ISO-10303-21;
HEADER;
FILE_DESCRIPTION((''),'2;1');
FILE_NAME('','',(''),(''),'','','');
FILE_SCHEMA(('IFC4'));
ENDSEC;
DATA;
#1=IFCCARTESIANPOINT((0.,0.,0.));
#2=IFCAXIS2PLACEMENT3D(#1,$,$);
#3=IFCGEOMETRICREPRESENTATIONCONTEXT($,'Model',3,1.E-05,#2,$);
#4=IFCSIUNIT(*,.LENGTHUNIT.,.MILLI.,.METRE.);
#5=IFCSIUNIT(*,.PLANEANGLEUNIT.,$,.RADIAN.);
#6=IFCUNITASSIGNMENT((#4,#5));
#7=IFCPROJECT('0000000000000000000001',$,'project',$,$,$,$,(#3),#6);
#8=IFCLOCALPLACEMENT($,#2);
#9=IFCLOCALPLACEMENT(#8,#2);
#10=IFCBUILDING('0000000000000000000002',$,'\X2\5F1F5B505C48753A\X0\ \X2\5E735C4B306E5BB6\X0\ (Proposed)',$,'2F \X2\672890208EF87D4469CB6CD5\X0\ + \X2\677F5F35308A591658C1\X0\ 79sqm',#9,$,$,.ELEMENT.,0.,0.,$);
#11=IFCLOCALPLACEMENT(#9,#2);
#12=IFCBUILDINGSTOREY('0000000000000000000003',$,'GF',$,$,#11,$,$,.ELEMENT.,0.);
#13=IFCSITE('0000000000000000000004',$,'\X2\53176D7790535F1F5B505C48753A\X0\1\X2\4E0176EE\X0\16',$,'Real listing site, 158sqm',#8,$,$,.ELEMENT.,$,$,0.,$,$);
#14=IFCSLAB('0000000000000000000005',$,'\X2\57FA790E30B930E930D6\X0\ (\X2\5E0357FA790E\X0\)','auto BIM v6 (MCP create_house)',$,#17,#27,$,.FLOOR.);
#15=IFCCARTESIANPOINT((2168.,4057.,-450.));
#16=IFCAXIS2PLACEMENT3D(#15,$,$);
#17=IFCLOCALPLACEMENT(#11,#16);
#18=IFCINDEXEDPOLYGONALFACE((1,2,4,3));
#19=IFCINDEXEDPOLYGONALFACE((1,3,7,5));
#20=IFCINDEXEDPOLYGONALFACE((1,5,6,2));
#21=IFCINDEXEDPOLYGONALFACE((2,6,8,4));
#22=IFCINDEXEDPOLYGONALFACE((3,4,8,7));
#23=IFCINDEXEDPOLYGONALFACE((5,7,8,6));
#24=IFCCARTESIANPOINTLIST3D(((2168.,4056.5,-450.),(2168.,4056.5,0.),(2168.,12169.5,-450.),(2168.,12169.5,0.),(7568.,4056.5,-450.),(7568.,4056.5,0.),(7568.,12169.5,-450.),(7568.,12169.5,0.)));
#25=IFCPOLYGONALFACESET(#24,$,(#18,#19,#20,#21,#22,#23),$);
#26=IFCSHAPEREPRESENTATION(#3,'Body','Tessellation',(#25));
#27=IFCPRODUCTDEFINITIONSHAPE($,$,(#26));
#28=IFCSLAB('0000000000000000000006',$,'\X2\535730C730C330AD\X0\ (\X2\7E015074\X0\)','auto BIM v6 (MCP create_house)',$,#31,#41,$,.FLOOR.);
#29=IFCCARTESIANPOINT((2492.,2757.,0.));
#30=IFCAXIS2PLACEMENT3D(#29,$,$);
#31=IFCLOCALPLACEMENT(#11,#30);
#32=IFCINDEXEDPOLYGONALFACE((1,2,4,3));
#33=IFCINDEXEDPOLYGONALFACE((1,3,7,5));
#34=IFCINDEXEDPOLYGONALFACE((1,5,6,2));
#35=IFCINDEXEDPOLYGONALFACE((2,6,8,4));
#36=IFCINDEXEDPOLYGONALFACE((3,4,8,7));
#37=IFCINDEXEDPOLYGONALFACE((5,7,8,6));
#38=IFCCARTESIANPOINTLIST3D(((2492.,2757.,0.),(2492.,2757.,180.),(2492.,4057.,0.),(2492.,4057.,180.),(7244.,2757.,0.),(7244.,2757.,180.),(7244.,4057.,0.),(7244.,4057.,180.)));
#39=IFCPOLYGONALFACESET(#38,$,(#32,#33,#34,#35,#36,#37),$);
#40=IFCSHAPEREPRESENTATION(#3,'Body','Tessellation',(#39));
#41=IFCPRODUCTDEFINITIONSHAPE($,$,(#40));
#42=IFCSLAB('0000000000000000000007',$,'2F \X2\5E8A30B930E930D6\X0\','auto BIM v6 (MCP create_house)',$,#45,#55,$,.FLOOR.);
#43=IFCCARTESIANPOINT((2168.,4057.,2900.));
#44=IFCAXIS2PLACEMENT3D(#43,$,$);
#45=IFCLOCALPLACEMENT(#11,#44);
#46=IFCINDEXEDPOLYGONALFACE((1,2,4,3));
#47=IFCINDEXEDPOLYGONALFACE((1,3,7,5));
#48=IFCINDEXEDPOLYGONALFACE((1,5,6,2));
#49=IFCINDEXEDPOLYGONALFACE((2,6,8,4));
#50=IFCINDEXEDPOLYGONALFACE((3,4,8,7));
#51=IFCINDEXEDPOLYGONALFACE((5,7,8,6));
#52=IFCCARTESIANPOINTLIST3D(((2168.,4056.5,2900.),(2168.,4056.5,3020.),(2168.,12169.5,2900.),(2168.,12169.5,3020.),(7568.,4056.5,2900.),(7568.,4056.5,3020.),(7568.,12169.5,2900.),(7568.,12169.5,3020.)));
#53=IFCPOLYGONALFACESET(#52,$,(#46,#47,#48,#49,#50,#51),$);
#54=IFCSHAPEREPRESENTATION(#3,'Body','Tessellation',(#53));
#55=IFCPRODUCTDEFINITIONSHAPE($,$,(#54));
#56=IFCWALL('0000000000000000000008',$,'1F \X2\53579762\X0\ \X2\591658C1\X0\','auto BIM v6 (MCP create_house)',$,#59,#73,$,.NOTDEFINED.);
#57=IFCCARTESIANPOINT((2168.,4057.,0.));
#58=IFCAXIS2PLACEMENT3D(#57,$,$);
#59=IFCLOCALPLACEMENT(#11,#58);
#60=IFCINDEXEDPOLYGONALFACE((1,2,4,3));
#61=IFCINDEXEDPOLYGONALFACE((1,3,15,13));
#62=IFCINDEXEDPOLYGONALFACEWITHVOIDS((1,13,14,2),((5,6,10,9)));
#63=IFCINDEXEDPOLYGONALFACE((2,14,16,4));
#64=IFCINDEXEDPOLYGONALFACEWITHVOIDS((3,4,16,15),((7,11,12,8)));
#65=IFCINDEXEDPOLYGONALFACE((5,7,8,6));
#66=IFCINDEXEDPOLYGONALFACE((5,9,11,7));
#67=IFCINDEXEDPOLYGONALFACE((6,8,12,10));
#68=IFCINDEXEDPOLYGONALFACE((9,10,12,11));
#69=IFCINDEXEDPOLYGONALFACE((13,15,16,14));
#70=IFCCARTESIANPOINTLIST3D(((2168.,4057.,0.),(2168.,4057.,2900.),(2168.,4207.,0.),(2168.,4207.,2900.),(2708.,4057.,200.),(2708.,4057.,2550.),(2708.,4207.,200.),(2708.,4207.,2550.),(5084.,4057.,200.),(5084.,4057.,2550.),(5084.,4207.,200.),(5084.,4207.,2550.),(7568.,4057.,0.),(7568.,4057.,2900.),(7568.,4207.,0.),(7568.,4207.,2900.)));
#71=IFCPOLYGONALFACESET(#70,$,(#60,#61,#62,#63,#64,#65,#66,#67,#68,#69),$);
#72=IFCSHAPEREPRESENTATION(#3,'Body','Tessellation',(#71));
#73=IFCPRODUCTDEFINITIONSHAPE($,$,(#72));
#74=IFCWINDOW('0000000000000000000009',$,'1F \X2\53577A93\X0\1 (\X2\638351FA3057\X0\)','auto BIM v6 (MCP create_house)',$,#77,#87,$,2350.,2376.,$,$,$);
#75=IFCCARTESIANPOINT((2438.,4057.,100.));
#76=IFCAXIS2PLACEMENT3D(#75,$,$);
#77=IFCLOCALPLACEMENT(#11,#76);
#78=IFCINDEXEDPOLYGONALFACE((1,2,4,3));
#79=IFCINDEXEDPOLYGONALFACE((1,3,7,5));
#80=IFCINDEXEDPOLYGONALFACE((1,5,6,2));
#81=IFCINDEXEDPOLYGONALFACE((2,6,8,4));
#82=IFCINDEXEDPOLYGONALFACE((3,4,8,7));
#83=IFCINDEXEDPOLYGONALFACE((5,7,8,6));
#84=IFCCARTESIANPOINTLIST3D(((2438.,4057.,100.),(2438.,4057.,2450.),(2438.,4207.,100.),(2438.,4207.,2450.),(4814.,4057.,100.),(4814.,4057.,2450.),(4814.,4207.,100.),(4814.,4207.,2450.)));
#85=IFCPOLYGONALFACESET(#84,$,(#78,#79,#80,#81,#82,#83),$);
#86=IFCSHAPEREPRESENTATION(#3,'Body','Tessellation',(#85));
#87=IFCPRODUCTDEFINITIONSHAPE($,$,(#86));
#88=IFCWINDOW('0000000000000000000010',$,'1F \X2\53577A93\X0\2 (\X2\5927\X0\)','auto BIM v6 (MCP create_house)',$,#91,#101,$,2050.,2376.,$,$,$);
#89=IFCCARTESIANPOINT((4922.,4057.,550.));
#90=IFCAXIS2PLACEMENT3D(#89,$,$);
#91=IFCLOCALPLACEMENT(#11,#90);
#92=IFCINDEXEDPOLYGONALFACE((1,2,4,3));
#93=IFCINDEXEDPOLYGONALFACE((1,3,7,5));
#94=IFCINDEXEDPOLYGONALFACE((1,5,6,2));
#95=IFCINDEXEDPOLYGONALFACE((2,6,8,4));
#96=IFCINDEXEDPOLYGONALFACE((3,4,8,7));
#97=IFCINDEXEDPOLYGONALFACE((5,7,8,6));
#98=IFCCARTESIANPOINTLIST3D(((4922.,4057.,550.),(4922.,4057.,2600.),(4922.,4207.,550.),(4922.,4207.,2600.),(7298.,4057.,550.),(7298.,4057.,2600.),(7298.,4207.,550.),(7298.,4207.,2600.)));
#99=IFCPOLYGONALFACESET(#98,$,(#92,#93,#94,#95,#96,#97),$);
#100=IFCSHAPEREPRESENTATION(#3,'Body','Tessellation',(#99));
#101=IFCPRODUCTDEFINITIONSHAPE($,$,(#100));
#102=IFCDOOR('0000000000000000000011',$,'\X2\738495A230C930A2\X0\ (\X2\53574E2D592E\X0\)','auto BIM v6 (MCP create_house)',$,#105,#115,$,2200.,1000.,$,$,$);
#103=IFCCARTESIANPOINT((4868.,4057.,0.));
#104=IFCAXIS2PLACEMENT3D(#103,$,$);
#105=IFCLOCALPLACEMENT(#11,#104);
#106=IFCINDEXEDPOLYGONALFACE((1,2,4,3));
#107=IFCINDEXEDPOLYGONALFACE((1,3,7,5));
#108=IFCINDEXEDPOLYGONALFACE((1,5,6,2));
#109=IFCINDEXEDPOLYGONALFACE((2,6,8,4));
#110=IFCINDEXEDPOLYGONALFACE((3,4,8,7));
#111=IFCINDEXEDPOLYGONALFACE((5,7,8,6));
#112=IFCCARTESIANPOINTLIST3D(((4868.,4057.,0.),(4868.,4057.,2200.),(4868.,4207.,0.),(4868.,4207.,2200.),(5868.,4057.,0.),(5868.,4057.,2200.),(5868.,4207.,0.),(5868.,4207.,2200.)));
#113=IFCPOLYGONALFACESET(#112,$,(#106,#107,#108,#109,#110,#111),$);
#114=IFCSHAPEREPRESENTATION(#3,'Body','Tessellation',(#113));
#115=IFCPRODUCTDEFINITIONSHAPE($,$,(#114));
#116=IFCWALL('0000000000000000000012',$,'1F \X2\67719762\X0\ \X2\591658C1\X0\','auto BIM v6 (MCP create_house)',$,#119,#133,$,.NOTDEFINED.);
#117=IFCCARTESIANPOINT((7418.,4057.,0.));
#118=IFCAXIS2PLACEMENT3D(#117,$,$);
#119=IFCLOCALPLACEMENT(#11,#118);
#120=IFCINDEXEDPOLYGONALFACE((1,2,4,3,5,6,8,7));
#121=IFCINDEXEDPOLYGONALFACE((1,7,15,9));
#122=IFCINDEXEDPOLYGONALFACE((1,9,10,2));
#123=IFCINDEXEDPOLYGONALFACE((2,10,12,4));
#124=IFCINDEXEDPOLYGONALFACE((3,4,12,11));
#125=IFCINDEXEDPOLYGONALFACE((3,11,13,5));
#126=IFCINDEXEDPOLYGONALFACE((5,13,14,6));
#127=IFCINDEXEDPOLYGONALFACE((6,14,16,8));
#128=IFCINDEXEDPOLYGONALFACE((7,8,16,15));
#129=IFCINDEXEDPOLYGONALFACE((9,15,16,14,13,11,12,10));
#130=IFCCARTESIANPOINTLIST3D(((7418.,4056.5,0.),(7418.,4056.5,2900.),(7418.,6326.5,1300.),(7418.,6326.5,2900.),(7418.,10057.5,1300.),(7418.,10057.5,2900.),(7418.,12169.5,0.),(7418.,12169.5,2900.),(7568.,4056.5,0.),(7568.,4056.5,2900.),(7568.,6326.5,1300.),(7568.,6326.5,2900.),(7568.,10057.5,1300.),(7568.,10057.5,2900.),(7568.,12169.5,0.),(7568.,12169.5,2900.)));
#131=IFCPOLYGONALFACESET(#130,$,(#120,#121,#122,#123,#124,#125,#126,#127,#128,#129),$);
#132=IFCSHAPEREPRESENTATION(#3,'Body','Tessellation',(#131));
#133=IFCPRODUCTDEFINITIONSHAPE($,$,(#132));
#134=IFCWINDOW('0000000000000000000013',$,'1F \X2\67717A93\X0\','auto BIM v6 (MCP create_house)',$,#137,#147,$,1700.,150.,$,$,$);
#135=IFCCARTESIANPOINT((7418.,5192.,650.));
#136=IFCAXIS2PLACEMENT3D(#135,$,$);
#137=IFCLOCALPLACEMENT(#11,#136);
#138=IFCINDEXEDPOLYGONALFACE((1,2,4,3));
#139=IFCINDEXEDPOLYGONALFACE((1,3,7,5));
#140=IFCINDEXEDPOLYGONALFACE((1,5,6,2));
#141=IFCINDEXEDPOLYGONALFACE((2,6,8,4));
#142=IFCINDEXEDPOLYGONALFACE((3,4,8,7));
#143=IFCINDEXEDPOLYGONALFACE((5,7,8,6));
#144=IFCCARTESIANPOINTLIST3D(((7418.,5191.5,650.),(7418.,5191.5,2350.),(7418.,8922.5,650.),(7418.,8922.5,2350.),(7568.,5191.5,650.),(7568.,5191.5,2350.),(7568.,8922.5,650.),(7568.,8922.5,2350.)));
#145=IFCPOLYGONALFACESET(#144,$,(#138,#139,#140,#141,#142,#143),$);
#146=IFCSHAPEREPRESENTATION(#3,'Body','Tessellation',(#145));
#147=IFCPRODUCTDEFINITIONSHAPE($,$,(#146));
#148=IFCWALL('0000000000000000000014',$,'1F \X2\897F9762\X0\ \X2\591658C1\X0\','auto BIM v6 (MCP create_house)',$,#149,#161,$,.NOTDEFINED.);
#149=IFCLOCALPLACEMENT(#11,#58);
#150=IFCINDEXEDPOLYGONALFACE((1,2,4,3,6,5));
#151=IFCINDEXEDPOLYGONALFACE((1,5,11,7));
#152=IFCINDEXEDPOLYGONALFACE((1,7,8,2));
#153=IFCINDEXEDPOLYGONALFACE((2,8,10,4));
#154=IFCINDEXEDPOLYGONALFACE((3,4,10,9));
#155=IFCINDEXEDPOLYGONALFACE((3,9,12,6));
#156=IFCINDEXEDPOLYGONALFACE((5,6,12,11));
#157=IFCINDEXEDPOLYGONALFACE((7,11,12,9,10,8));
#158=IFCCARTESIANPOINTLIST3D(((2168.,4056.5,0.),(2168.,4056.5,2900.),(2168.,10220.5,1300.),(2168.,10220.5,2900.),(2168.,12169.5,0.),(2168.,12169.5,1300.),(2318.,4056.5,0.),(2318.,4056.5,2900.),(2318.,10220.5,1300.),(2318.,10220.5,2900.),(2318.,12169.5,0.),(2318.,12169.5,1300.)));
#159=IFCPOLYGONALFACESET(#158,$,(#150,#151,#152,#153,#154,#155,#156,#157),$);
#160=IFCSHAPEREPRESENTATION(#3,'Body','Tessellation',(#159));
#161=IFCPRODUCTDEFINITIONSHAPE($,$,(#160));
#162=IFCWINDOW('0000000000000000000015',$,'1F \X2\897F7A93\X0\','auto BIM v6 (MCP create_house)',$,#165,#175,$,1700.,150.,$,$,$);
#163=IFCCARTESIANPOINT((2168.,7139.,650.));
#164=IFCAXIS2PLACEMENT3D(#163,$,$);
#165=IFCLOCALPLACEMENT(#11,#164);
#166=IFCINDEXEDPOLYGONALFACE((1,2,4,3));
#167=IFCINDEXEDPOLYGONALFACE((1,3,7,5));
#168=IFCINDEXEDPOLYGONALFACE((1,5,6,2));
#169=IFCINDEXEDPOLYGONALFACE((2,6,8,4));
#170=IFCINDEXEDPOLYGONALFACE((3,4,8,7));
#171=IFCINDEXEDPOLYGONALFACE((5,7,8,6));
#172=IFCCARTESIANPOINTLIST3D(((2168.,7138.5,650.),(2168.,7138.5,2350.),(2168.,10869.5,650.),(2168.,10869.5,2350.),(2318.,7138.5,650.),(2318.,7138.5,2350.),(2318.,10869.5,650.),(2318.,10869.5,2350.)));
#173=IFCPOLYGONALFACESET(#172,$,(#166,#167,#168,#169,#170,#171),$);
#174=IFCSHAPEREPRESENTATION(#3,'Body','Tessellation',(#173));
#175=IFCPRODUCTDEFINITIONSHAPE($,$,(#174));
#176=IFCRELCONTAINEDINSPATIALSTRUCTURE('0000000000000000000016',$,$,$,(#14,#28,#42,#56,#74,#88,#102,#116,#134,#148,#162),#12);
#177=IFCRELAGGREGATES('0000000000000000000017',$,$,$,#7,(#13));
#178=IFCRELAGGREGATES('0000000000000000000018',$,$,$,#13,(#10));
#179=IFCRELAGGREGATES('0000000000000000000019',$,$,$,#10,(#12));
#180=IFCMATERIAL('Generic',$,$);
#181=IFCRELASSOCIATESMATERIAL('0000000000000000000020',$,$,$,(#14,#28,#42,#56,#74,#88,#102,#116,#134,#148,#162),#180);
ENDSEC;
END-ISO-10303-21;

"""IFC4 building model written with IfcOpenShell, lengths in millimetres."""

from ifc_helpers import new_model, si_unit, frame, frame_2d, origin, place, context, project, spatial, rectangle, extrude, material, element, fill, save


model = new_model("IFC4")

# Units and contexts
model_context = context("Model", 3, precision=1e-05, world=origin())
ifc_project = project(units=[si_unit("LENGTHUNIT", "METRE", prefix="MILLI"), si_unit("PLANEANGLEUNIT", "RADIAN")], contexts=[model_context])

# Site, building, storey
site_placement = place(None, origin())
site = spatial("IfcSite", under=ifc_project, at=site_placement, Name="北海道弟子屈町1丁目16", ObjectType="Real listing site, 158sqm", CompositionType="ELEMENT", RefElevation=0.0)
building_placement = place(site_placement, origin())
building = spatial("IfcBuilding", under=site, at=building_placement, Name="弟子屈町 平屋の家 (Proposed)", ObjectType="2F 木造軸組構法 + 板張り外壁 79sqm", CompositionType="ELEMENT", ElevationOfRefHeight=0.0, ElevationOfTerrain=0.0)
storey_placement = place(building_placement, origin())
storey = spatial("IfcBuildingStorey", under=building, at=storey_placement, Name="GF", CompositionType="ELEMENT", Elevation=0.0)

# Slabs
ifc_material = material(Name="Generic")
slab_1_placement = place(storey_placement, frame((2168.0, 4057.0, -450.0)))
element("IfcSlab", 1, at=slab_1_placement, inside=storey, material=ifc_material, Name="基礎スラブ (布基礎)", Description="auto BIM v6 (MCP create_house)", PredefinedType="FLOOR", context=model_context, shape_type="SweptSolid", body=[
    extrude(rectangle(XDim=5400.0, YDim=8113.0, at=frame_2d((2700.0, 4056.0))), frame((2168.0, 4057.0, -450.0)), (0.0, 0.0, 1.0), 450.0),
])
slab_2_placement = place(storey_placement, frame((2492.0, 2757.0, 0.0)))
element("IfcSlab", 2, at=slab_2_placement, inside=storey, material=ifc_material, Name="南デッキ (縁側)", Description="auto BIM v6 (MCP create_house)", PredefinedType="FLOOR", context=model_context, shape_type="SweptSolid", body=[
    extrude(rectangle(XDim=4752.0, YDim=1300.0, at=frame_2d((2376.0, 650.0))), frame((2492.0, 2757.0, 0.0)), (0.0, 0.0, 1.0), 180.0),
])
slab_3_placement = place(storey_placement, frame((2168.0, 4057.0, 2900.0)))
element("IfcSlab", 3, at=slab_3_placement, inside=storey, material=ifc_material, Name="2F 床スラブ", Description="auto BIM v6 (MCP create_house)", PredefinedType="FLOOR", context=model_context, shape_type="SweptSolid", body=[
    extrude(rectangle(XDim=5400.0, YDim=8113.0, at=frame_2d((2700.0, 4056.0))), frame((2168.0, 4057.0, 2900.0)), (0.0, 0.0, 1.0), 120.0),
])

# Wall, openings, windows, door
wall_1_placement = place(storey_placement, frame((2168.0, 4057.0, 0.0)))
wall_1 = element("IfcWall", 4, at=wall_1_placement, inside=storey, material=ifc_material, Name="1F 南面 外壁", Description="auto BIM v6 (MCP create_house)", PredefinedType="NOTDEFINED", context=model_context, shape_type="SweptSolid", body=[
    extrude(rectangle(XDim=5400.0, YDim=150.0, at=frame_2d((2700.0, 75.0))), frame((2168.0, 4057.0, 0.0)), (0.0, 0.0, 1.0), 2900.0),
])
opening_1_placement = place(storey_placement, frame((2438.0, 4057.0, 100.0)))
opening_1 = element("IfcOpeningElement", 5, at=opening_1_placement, cuts=wall_1, PredefinedType="NOTDEFINED", context=model_context, shape_type="SweptSolid", body=[
    extrude(rectangle(XDim=2376.0, YDim=150.0, at=frame_2d((1188.0, 75.0))), frame((2438.0, 4057.0, 100.0)), (0.0, 0.0, 1.0), 2350.0),
])
opening_2_placement = place(storey_placement, frame((4922.0, 4057.0, 550.0)))
opening_2 = element("IfcOpeningElement", 6, at=opening_2_placement, cuts=wall_1, PredefinedType="NOTDEFINED", context=model_context, shape_type="SweptSolid", body=[
    extrude(rectangle(XDim=2376.0, YDim=150.0, at=frame_2d((1188.0, 75.0))), frame((4922.0, 4057.0, 550.0)), (0.0, 0.0, 1.0), 2050.0),
])
opening_3_placement = place(storey_placement, frame((4868.0, 4057.0, 0.0)))
opening_3 = element("IfcOpeningElement", 7, at=opening_3_placement, cuts=wall_1, PredefinedType="NOTDEFINED", context=model_context, shape_type="SweptSolid", body=[
    extrude(rectangle(XDim=1000.0, YDim=150.0, at=frame_2d((500.0, 75.0))), frame((4868.0, 4057.0, 0.0)), (0.0, 0.0, 1.0), 2200.0),
])
window_1_placement = place(storey_placement, frame((2438.0, 4057.0, 100.0)))
window_1 = element("IfcWindow", 8, at=window_1_placement, inside=storey, material=ifc_material, Name="1F 南窓1 (掃出し)", Description="auto BIM v6 (MCP create_house)", OverallHeight=2350.0, OverallWidth=2376.0, context=model_context, shape_type="SweptSolid", body=[
    extrude(rectangle(XDim=2376.0, YDim=150.0, at=frame_2d((1188.0, 75.0))), frame((2438.0, 4057.0, 100.0)), (0.0, 0.0, 1.0), 2350.0),
])
fill(opening_1, window_1)
window_2_placement = place(storey_placement, frame((4922.0, 4057.0, 550.0)))
window_2 = element("IfcWindow", 9, at=window_2_placement, inside=storey, material=ifc_material, Name="1F 南窓2 (大)", Description="auto BIM v6 (MCP create_house)", OverallHeight=2050.0, OverallWidth=2376.0, context=model_context, shape_type="SweptSolid", body=[
    extrude(rectangle(XDim=2376.0, YDim=150.0, at=frame_2d((1188.0, 75.0))), frame((4922.0, 4057.0, 550.0)), (0.0, 0.0, 1.0), 2050.0),
])
fill(opening_2, window_2)
door_placement = place(storey_placement, frame((4868.0, 4057.0, 0.0)))
door = element("IfcDoor", 10, at=door_placement, inside=storey, material=ifc_material, Name="玄関ドア (南中央)", Description="auto BIM v6 (MCP create_house)", OverallHeight=2200.0, OverallWidth=1000.0, context=model_context, shape_type="SweptSolid", body=[
    extrude(rectangle(XDim=1000.0, YDim=150.0, at=frame_2d((500.0, 75.0))), frame((4868.0, 4057.0, 0.0)), (0.0, 0.0, 1.0), 2200.0),
])
fill(opening_3, door)

# Walls, openings, windows
wall_2_placement = place(storey_placement, frame((7418.0, 4057.0, 0.0)))
wall_2 = element("IfcWall", 11, at=wall_2_placement, inside=storey, material=ifc_material, Name="1F 東面 外壁", Description="auto BIM v6 (MCP create_house)", PredefinedType="NOTDEFINED", context=model_context, shape_type="SweptSolid", body=[
    extrude(rectangle(XDim=150.0, YDim=8113.0, at=frame_2d((75.0, 4056.0))), frame((7418.0, 4057.0, 0.0)), (0.0, 0.0, 1.0), 2900.0),
])
opening_4_placement = place(storey_placement, frame((7418.0, 5192.0, 650.0)))
opening_4 = element("IfcOpeningElement", 12, at=opening_4_placement, cuts=wall_2, PredefinedType="NOTDEFINED", context=model_context, shape_type="SweptSolid", body=[
    extrude(rectangle(XDim=150.0, YDim=3731.0, at=frame_2d((75.0, 1865.0))), frame((7418.0, 5192.0, 650.0)), (0.0, 0.0, 1.0), 1700.0),
])
window_3_placement = place(storey_placement, frame((7418.0, 5192.0, 650.0)))
window_3 = element("IfcWindow", 13, at=window_3_placement, inside=storey, material=ifc_material, Name="1F 東窓", Description="auto BIM v6 (MCP create_house)", OverallHeight=1700.0, OverallWidth=150.0, context=model_context, shape_type="SweptSolid", body=[
    extrude(rectangle(XDim=150.0, YDim=3731.0, at=frame_2d((75.0, 1865.0))), frame((7418.0, 5192.0, 650.0)), (0.0, 0.0, 1.0), 1700.0),
])
fill(opening_4, window_3)
wall_3_placement = place(storey_placement, frame((2168.0, 4057.0, 0.0)))
wall_3 = element("IfcWall", 14, at=wall_3_placement, inside=storey, material=ifc_material, Name="1F 西面 外壁", Description="auto BIM v6 (MCP create_house)", PredefinedType="NOTDEFINED", context=model_context, shape_type="SweptSolid", body=[
    extrude(rectangle(XDim=150.0, YDim=8113.0, at=frame_2d((75.0, 4056.0))), frame((2168.0, 4057.0, 0.0)), (0.0, 0.0, 1.0), 2900.0),
])
opening_5_placement = place(storey_placement, frame((2168.0, 7139.0, 650.0)))
opening_5 = element("IfcOpeningElement", 15, at=opening_5_placement, cuts=wall_3, PredefinedType="NOTDEFINED", context=model_context, shape_type="SweptSolid", body=[
    extrude(rectangle(XDim=150.0, YDim=3731.0, at=frame_2d((75.0, 1865.0))), frame((2168.0, 7139.0, 650.0)), (0.0, 0.0, 1.0), 1700.0),
])
window_4_placement = place(storey_placement, frame((2168.0, 7139.0, 650.0)))
window_4 = element("IfcWindow", 16, at=window_4_placement, inside=storey, material=ifc_material, Name="1F 西窓", Description="auto BIM v6 (MCP create_house)", OverallHeight=1700.0, OverallWidth=150.0, context=model_context, shape_type="SweptSolid", body=[
    extrude(rectangle(XDim=150.0, YDim=3731.0, at=frame_2d((75.0, 1865.0))), frame((2168.0, 7139.0, 650.0)), (0.0, 0.0, 1.0), 1700.0),
])
fill(opening_5, window_4)

save(model, "model.ifc")
